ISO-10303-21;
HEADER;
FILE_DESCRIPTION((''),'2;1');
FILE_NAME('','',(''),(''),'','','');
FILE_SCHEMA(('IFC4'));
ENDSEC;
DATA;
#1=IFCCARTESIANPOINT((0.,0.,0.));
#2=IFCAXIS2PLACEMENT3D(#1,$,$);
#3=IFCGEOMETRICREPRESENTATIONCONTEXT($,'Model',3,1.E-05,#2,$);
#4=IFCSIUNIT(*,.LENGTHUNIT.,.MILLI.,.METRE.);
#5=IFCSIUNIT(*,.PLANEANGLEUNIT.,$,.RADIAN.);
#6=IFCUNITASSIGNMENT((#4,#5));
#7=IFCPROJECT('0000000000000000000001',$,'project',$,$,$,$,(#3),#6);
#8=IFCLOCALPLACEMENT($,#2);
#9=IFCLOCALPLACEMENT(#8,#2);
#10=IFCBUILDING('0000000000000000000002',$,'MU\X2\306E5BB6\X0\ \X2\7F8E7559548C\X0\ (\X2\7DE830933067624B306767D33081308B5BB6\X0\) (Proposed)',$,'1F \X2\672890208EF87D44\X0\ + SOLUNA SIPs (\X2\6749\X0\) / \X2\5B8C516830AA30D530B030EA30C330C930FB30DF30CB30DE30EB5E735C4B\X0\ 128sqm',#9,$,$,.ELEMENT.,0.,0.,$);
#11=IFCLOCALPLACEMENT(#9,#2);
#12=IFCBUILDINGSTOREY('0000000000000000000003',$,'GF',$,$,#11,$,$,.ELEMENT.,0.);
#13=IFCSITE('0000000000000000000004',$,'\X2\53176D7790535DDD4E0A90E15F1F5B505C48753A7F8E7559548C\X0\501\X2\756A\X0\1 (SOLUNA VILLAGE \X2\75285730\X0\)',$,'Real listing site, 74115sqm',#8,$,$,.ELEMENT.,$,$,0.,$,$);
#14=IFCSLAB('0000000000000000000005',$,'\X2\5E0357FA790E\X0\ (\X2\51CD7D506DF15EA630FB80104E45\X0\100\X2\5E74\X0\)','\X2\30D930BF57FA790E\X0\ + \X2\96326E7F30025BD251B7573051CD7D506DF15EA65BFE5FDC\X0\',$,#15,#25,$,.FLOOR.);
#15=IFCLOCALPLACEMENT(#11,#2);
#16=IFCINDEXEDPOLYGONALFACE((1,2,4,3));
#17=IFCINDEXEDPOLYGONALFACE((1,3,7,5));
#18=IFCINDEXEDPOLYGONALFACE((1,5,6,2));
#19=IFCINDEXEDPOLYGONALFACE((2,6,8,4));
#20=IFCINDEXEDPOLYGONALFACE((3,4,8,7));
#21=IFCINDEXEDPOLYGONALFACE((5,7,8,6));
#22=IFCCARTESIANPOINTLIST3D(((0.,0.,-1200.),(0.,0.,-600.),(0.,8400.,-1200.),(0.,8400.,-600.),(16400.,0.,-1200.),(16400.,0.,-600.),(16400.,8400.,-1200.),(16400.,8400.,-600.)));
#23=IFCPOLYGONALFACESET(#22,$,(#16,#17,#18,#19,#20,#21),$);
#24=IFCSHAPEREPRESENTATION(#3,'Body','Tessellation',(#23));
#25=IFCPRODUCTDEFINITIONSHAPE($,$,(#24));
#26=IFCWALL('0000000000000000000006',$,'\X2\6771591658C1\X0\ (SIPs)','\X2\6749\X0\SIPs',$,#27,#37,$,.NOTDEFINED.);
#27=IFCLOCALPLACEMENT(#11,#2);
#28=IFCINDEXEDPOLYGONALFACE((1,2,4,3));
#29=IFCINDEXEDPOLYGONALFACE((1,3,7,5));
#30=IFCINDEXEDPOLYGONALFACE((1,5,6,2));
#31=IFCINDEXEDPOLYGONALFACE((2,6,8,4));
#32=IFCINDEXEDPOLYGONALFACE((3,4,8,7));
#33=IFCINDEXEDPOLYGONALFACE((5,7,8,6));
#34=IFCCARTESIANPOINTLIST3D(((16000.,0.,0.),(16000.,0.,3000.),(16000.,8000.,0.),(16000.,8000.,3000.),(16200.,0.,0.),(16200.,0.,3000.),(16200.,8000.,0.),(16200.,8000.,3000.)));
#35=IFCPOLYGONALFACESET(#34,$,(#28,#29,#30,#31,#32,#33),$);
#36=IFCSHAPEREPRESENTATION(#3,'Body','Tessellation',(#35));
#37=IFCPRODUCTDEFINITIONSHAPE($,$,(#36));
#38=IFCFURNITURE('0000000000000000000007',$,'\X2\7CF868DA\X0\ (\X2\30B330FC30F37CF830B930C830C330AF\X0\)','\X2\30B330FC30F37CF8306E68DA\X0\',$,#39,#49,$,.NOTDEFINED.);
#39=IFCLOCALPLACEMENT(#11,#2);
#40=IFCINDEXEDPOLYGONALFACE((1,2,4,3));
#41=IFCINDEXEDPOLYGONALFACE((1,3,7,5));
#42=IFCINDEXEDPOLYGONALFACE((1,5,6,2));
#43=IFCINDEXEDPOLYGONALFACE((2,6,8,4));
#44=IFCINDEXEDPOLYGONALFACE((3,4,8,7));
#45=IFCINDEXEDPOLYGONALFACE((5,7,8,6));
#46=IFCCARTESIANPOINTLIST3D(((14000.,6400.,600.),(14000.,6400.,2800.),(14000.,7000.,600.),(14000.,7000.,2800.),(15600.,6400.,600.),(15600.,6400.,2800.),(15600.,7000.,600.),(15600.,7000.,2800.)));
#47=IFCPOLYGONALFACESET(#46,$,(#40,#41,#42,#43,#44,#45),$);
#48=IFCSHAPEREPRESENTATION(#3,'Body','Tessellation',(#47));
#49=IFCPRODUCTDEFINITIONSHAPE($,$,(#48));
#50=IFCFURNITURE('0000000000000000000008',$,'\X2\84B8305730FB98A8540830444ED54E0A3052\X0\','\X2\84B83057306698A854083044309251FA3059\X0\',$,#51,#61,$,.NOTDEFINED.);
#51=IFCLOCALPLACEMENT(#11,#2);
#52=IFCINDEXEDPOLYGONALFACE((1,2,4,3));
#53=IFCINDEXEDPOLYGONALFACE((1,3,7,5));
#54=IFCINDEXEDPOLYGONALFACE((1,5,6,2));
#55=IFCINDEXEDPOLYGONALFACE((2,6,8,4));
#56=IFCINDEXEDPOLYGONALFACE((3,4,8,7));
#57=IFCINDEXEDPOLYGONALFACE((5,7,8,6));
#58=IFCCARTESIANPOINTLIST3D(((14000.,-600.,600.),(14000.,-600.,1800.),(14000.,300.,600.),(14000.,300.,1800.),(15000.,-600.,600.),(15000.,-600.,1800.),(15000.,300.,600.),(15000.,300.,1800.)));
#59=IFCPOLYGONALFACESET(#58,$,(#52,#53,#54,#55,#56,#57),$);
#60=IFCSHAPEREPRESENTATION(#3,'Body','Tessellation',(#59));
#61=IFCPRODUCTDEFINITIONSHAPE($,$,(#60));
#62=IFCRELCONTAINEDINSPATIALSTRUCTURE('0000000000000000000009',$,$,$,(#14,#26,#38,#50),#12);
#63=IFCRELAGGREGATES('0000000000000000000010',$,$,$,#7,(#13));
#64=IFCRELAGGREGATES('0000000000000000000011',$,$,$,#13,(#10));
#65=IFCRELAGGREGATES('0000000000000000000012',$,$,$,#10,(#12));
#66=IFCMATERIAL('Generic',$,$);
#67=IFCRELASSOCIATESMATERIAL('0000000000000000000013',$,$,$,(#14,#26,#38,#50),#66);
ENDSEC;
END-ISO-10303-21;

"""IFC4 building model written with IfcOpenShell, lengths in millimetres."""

from ifc_helpers import new_model, si_unit, frame, frame_2d, origin, place, context, project, spatial, rectangle, extrude, material, element, save


model = new_model("IFC4")

# Units and contexts
model_context = context("Model", 3, precision=1e-05, world=origin())
ifc_project = project(units=[si_unit("LENGTHUNIT", "METRE", prefix="MILLI"), si_unit("PLANEANGLEUNIT", "RADIAN")], contexts=[model_context])

# Site, building, storey
site_placement = place(None, origin())
site = spatial("IfcSite", under=ifc_project, at=site_placement, Name="北海道川上郡弟子屈町美留和501番1 (SOLUNA VILLAGE 用地)", ObjectType="Real listing site, 74115sqm", CompositionType="ELEMENT", RefElevation=0.0)
building_placement = place(site_placement, origin())
building = spatial("IfcBuilding", under=site, at=building_placement, Name="MUの家 美留和 (編んで手で染める家) (Proposed)", ObjectType="1F 木造軸組 + SOLUNA SIPs (杉) / 完全オフグリッド・ミニマル平屋 128sqm", CompositionType="ELEMENT", ElevationOfRefHeight=0.0, ElevationOfTerrain=0.0)
storey_placement = place(building_placement, origin())
storey = spatial("IfcBuildingStorey", under=building, at=storey_placement, Name="GF", CompositionType="ELEMENT", Elevation=0.0)

# Slab
ifc_material_1 = material(Name="Generic")
slab_1_placement = place(storey_placement, frame((0.0, 0.0, -600.0)))
element("IfcSlab", 1, at=slab_1_placement, inside=storey, material=ifc_material_1, Name="布基礎 (凍結深度・耐久100年)", Description="ベタ基礎 + 防湿。寒冷地凍結深度対応", PredefinedType="FLOOR", context=model_context, shape_type="SweptSolid", body=[
    extrude(rectangle(XDim=16400.0, YDim=8400.0, at=frame_2d((8200.0, 4200.0))), frame((0.0, 0.0, -600.0)), (0.0, 0.0, 1.0), 600.0),
])

# Wall
wall_1_placement = place(storey_placement, frame((8000.0, 0.0, 0.0)))
element("IfcWall", 2, at=wall_1_placement, inside=storey, material=ifc_material_1, Name="東外壁 (SIPs)", Description="杉SIPs", PredefinedType="NOTDEFINED", context=model_context, shape_type="SweptSolid", body=[
    extrude(rectangle(XDim=200.0, YDim=8000.0, at=frame_2d((100.0, 4000.0))), frame((8000.0, 0.0, 0.0)), (0.0, 0.0, 1.0), 3000.0),
])

# Furniture
furniture_1_placement = place(storey_placement, frame((7000.0, 3200.0, 300.0)))
element("IfcFurniture", 3, at=furniture_1_placement, inside=storey, material=ifc_material_1, Name="糸棚 (コーン糸ストック)", Description="コーン糸の棚", PredefinedType="NOTDEFINED", context=model_context, shape_type="SweptSolid", body=[
    extrude(rectangle(XDim=1600.0, YDim=600.0, at=frame_2d((800.0, 300.0))), frame((7000.0, 3200.0, 300.0)), (0.0, 0.0, 1.0), 2200.0),
])
furniture_2_placement = place(storey_placement, frame((7000.0, -300.0, 300.0)))
element("IfcFurniture", 4, at=furniture_2_placement, inside=storey, material=ifc_material_1, Name="蒸し・風合い仕上げ", Description="蒸して風合いを出す", PredefinedType="NOTDEFINED", context=model_context, shape_type="SweptSolid", body=[
    extrude(rectangle(XDim=1000.0, YDim=900.0, at=frame_2d((500.0, 450.0))), frame((7000.0, -300.0, 300.0)), (0.0, 0.0, 1.0), 1200.0),
])

save(model, "model.ifc")
